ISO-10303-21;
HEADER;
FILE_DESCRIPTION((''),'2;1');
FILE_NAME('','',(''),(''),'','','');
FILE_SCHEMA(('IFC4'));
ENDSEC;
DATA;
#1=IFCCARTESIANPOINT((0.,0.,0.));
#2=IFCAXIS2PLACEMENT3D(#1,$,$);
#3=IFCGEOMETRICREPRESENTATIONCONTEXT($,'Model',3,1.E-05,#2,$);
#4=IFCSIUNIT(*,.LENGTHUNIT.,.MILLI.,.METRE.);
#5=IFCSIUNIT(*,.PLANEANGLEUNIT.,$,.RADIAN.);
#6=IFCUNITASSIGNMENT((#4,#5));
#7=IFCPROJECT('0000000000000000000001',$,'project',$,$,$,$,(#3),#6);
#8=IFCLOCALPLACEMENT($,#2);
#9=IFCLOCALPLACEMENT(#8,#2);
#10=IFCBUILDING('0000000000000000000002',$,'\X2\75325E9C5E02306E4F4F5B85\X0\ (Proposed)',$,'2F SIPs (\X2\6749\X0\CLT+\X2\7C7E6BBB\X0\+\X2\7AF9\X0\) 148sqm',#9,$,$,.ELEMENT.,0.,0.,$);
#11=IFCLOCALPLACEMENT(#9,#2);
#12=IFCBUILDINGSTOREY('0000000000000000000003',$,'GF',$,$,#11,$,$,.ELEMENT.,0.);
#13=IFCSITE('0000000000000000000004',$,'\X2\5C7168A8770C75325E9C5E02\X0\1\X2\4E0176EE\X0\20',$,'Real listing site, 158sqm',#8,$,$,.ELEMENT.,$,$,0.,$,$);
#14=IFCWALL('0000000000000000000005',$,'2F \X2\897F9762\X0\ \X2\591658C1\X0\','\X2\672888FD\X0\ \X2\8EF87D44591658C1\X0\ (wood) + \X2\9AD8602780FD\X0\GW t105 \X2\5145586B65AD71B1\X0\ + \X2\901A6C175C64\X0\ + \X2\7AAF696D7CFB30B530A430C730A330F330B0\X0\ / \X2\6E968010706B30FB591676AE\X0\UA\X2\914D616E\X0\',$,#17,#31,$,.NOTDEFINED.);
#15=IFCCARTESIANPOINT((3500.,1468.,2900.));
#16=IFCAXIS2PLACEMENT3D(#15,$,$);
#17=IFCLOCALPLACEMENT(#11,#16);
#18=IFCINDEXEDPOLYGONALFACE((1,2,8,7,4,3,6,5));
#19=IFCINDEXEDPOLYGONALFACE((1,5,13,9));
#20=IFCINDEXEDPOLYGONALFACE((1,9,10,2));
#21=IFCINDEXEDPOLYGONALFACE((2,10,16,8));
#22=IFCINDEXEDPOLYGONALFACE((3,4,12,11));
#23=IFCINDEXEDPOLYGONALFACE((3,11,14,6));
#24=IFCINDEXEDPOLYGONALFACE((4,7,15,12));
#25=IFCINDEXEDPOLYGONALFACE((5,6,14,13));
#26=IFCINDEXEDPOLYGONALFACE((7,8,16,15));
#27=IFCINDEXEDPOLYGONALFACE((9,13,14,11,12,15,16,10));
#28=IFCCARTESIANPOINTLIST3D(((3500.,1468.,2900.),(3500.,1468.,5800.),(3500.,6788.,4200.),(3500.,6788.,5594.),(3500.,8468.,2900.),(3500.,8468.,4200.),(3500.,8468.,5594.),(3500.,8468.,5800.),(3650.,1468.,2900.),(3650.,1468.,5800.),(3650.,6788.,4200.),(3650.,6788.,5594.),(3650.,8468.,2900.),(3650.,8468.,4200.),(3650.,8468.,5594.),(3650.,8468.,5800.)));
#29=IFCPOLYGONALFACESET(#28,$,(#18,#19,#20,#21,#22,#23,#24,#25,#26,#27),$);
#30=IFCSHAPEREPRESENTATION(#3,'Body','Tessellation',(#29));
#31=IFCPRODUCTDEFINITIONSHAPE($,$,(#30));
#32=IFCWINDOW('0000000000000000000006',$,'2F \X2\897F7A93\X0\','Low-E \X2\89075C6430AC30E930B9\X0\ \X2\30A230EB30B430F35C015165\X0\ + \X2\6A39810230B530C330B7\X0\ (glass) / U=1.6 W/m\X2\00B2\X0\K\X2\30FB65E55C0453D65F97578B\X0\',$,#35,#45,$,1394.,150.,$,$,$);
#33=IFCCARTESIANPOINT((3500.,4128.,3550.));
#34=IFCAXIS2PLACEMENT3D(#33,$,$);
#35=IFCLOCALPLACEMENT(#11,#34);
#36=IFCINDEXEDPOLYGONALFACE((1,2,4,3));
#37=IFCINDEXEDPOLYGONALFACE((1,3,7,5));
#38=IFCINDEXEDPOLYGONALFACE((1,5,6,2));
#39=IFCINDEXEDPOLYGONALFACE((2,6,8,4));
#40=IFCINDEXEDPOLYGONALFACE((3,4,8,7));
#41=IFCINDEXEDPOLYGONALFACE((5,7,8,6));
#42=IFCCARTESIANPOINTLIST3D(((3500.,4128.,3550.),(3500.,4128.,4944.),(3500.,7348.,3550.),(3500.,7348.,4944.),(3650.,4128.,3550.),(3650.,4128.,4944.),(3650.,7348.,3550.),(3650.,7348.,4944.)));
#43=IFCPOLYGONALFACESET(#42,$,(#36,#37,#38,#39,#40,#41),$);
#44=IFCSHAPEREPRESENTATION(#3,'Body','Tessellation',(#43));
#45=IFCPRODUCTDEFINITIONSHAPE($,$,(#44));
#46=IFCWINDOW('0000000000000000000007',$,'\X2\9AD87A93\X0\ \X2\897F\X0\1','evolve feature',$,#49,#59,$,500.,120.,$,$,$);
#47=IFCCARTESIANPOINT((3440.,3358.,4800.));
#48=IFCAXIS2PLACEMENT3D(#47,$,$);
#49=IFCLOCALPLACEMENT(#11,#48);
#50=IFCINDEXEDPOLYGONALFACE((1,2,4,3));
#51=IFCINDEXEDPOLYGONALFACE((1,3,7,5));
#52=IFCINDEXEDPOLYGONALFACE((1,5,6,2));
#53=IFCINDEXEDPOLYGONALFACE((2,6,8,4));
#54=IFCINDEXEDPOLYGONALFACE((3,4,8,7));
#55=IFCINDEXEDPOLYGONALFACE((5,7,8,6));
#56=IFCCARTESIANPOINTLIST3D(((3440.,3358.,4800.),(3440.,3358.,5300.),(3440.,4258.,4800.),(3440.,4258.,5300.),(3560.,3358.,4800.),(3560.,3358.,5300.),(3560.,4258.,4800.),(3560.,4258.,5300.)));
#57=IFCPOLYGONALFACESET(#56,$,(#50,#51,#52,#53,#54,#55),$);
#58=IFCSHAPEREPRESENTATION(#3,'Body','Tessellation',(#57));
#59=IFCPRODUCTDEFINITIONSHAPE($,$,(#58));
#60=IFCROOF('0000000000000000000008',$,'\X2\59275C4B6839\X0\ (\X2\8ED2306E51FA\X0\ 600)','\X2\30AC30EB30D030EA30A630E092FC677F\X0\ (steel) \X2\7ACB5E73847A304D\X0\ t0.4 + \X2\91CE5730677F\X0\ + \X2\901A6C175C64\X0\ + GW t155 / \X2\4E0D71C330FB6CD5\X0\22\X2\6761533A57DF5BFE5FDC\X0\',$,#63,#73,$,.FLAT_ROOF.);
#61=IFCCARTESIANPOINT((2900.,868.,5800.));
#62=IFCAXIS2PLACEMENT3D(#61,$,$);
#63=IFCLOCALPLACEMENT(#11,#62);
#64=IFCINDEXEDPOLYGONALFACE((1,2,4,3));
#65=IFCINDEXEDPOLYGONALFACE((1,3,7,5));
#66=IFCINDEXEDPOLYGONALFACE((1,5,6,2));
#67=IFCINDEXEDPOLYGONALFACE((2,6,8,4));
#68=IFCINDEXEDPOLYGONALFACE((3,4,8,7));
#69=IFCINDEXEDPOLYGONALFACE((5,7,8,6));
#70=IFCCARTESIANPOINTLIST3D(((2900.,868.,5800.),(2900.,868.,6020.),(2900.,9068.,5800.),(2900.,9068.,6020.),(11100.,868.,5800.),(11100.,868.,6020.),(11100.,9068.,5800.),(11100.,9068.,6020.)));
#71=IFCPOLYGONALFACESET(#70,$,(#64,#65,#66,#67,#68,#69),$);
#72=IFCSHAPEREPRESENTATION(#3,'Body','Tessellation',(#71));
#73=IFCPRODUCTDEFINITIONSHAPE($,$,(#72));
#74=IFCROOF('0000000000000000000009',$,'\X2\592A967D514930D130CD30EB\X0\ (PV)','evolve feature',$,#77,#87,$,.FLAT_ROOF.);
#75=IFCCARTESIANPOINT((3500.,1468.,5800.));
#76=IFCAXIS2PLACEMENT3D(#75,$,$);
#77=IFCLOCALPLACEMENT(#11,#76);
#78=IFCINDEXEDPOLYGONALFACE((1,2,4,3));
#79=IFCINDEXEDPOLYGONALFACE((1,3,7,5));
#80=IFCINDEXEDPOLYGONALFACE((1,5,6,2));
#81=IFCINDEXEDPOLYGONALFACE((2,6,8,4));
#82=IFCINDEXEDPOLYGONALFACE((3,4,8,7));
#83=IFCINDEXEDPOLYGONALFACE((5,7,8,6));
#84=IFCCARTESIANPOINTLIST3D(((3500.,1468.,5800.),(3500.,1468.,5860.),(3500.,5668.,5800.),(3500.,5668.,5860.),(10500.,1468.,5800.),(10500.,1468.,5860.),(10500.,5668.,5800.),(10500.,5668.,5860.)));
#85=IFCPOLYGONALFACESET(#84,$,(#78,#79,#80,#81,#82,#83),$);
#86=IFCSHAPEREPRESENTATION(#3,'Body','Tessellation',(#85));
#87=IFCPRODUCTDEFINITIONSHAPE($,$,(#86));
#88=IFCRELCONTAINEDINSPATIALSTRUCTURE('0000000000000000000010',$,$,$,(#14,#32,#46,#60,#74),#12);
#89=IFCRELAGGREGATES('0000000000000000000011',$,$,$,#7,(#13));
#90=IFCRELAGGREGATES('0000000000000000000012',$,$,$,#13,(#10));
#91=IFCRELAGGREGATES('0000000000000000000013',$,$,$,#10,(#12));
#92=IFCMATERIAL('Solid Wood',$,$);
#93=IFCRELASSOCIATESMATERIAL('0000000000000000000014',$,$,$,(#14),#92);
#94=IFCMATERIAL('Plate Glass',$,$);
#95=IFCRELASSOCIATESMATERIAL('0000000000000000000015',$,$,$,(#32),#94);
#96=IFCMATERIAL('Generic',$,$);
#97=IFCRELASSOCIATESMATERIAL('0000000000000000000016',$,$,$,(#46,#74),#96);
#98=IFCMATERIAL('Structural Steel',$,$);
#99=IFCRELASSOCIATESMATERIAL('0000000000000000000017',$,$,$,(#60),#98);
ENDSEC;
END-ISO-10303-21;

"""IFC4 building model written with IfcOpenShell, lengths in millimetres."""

from ifc_helpers import new_model, si_unit, frame, frame_2d, origin, place, context, project, spatial, rectangle, extrude, material, element, fill, save


model = new_model("IFC4")

# Units and contexts
model_context = context("Model", 3, precision=1e-05, world=origin())
ifc_project = project(units=[si_unit("LENGTHUNIT", "METRE", prefix="MILLI"), si_unit("PLANEANGLEUNIT", "RADIAN")], contexts=[model_context])

# Site, building, storey
site_placement = place(None, origin())
site = spatial("IfcSite", under=ifc_project, at=site_placement, Name="山梨県甲府市1丁目20", ObjectType="Real listing site, 158sqm", CompositionType="ELEMENT", RefElevation=0.0)
building_placement = place(site_placement, origin())
building = spatial("IfcBuilding", under=site, at=building_placement, Name="甲府市の住宅 (Proposed)", ObjectType="2F SIPs (杉CLT+籾殻+竹) 148sqm", CompositionType="ELEMENT", ElevationOfRefHeight=0.0, ElevationOfTerrain=0.0)
storey_placement = place(building_placement, origin())
storey = spatial("IfcBuildingStorey", under=building, at=storey_placement, Name="GF", CompositionType="ELEMENT", Elevation=0.0)

# Shared definitions
ifc_material_1 = material(Name="Solid Wood")
ifc_material_2 = material(Name="Generic")

# Shared definitions
ifc_material_3 = material(Name="Plate Glass")

# Wall, openings, windows
wall_1_placement = place(storey_placement, frame((3500.0, 1468.0, 2900.0)))
wall_1 = element("IfcWall", 1, at=wall_1_placement, inside=storey, material=ifc_material_1, Name="2F 西面 外壁", Description="木製 軸組外壁 (wood) + 高性能GW t105 充填断熱 + 通気層 + 窯業系サイディング / 準耐火・外皮UA配慮", PredefinedType="NOTDEFINED", context=model_context, shape_type="SweptSolid", body=[
    extrude(rectangle(XDim=150.0, YDim=7000.0, at=frame_2d((75.0, 3500.0))), frame((3500.0, 1468.0, 2900.0)), (0.0, 0.0, 1.0), 2900.0),
])
opening_1_placement = place(storey_placement, frame((3500.0, 4128.0, 3550.0)))
opening_1 = element("IfcOpeningElement", 2, at=opening_1_placement, cuts=wall_1, PredefinedType="NOTDEFINED", context=model_context, shape_type="SweptSolid", body=[
    extrude(rectangle(XDim=150.0, YDim=3220.0, at=frame_2d((75.0, 1610.0))), frame((3500.0, 4128.0, 3550.0)), (0.0, 0.0, 1.0), 1394.0),
])
opening_2_placement = place(storey_placement, frame((3440.0, 3358.0, 4800.0)))
opening_2 = element("IfcOpeningElement", 3, at=opening_2_placement, cuts=wall_1, PredefinedType="NOTDEFINED", context=model_context, shape_type="SweptSolid", body=[
    extrude(rectangle(XDim=120.0, YDim=900.0, at=frame_2d((60.0, 450.0))), frame((3440.0, 3358.0, 4800.0)), (0.0, 0.0, 1.0), 500.0),
])
window_1_placement = place(storey_placement, frame((3500.0, 4128.0, 3550.0)))
window_1 = element("IfcWindow", 4, at=window_1_placement, inside=storey, material=ifc_material_3, Name="2F 西窓", Description="Low-E 複層ガラス アルゴン封入 + 樹脂サッシ (glass) / U=1.6 W/m²K・日射取得型", OverallHeight=1394.0, OverallWidth=150.0, context=model_context, shape_type="SweptSolid", body=[
    extrude(rectangle(XDim=150.0, YDim=3220.0, at=frame_2d((75.0, 1610.0))), frame((3500.0, 4128.0, 3550.0)), (0.0, 0.0, 1.0), 1394.0),
])
fill(opening_1, window_1)
window_2_placement = place(storey_placement, frame((3440.0, 3358.0, 4800.0)))
window_2 = element("IfcWindow", 5, at=window_2_placement, inside=storey, material=ifc_material_2, Name="高窓 西1", Description="evolve feature", OverallHeight=500.0, OverallWidth=120.0, context=model_context, shape_type="SweptSolid", body=[
    extrude(rectangle(XDim=120.0, YDim=900.0, at=frame_2d((60.0, 450.0))), frame((3440.0, 3358.0, 4800.0)), (0.0, 0.0, 1.0), 500.0),
])
fill(opening_2, window_2)

# Roofs
ifc_material_4 = material(Name="Structural Steel")
roof_1_placement = place(storey_placement, frame((2900.0, 868.0, 5800.0)))
element("IfcRoof", 6, at=roof_1_placement, inside=storey, material=ifc_material_4, Name="大屋根 (軒の出 600)", Description="ガルバリウム鋼板 (steel) 立平葺き t0.4 + 野地板 + 通気層 + GW t155 / 不燃・法22条区域対応", PredefinedType="FLAT_ROOF", context=model_context, shape_type="SweptSolid", body=[
    extrude(rectangle(XDim=8200.0, YDim=8200.0, at=frame_2d((4100.0, 4100.0))), frame((2900.0, 868.0, 5800.0)), (0.0, 0.0, 1.0), 220.0),
])
roof_2_placement = place(storey_placement, frame((3500.0, 1468.0, 5800.0)))
element("IfcRoof", 7, at=roof_2_placement, inside=storey, material=ifc_material_2, Name="太陽光パネル (PV)", Description="evolve feature", PredefinedType="FLAT_ROOF", context=model_context, shape_type="SweptSolid", body=[
    extrude(rectangle(XDim=7000.0, YDim=4200.0, at=frame_2d((3500.0, 2100.0))), frame((3500.0, 1468.0, 5800.0)), (0.0, 0.0, 1.0), 60.0),
])

save(model, "model.ifc")
